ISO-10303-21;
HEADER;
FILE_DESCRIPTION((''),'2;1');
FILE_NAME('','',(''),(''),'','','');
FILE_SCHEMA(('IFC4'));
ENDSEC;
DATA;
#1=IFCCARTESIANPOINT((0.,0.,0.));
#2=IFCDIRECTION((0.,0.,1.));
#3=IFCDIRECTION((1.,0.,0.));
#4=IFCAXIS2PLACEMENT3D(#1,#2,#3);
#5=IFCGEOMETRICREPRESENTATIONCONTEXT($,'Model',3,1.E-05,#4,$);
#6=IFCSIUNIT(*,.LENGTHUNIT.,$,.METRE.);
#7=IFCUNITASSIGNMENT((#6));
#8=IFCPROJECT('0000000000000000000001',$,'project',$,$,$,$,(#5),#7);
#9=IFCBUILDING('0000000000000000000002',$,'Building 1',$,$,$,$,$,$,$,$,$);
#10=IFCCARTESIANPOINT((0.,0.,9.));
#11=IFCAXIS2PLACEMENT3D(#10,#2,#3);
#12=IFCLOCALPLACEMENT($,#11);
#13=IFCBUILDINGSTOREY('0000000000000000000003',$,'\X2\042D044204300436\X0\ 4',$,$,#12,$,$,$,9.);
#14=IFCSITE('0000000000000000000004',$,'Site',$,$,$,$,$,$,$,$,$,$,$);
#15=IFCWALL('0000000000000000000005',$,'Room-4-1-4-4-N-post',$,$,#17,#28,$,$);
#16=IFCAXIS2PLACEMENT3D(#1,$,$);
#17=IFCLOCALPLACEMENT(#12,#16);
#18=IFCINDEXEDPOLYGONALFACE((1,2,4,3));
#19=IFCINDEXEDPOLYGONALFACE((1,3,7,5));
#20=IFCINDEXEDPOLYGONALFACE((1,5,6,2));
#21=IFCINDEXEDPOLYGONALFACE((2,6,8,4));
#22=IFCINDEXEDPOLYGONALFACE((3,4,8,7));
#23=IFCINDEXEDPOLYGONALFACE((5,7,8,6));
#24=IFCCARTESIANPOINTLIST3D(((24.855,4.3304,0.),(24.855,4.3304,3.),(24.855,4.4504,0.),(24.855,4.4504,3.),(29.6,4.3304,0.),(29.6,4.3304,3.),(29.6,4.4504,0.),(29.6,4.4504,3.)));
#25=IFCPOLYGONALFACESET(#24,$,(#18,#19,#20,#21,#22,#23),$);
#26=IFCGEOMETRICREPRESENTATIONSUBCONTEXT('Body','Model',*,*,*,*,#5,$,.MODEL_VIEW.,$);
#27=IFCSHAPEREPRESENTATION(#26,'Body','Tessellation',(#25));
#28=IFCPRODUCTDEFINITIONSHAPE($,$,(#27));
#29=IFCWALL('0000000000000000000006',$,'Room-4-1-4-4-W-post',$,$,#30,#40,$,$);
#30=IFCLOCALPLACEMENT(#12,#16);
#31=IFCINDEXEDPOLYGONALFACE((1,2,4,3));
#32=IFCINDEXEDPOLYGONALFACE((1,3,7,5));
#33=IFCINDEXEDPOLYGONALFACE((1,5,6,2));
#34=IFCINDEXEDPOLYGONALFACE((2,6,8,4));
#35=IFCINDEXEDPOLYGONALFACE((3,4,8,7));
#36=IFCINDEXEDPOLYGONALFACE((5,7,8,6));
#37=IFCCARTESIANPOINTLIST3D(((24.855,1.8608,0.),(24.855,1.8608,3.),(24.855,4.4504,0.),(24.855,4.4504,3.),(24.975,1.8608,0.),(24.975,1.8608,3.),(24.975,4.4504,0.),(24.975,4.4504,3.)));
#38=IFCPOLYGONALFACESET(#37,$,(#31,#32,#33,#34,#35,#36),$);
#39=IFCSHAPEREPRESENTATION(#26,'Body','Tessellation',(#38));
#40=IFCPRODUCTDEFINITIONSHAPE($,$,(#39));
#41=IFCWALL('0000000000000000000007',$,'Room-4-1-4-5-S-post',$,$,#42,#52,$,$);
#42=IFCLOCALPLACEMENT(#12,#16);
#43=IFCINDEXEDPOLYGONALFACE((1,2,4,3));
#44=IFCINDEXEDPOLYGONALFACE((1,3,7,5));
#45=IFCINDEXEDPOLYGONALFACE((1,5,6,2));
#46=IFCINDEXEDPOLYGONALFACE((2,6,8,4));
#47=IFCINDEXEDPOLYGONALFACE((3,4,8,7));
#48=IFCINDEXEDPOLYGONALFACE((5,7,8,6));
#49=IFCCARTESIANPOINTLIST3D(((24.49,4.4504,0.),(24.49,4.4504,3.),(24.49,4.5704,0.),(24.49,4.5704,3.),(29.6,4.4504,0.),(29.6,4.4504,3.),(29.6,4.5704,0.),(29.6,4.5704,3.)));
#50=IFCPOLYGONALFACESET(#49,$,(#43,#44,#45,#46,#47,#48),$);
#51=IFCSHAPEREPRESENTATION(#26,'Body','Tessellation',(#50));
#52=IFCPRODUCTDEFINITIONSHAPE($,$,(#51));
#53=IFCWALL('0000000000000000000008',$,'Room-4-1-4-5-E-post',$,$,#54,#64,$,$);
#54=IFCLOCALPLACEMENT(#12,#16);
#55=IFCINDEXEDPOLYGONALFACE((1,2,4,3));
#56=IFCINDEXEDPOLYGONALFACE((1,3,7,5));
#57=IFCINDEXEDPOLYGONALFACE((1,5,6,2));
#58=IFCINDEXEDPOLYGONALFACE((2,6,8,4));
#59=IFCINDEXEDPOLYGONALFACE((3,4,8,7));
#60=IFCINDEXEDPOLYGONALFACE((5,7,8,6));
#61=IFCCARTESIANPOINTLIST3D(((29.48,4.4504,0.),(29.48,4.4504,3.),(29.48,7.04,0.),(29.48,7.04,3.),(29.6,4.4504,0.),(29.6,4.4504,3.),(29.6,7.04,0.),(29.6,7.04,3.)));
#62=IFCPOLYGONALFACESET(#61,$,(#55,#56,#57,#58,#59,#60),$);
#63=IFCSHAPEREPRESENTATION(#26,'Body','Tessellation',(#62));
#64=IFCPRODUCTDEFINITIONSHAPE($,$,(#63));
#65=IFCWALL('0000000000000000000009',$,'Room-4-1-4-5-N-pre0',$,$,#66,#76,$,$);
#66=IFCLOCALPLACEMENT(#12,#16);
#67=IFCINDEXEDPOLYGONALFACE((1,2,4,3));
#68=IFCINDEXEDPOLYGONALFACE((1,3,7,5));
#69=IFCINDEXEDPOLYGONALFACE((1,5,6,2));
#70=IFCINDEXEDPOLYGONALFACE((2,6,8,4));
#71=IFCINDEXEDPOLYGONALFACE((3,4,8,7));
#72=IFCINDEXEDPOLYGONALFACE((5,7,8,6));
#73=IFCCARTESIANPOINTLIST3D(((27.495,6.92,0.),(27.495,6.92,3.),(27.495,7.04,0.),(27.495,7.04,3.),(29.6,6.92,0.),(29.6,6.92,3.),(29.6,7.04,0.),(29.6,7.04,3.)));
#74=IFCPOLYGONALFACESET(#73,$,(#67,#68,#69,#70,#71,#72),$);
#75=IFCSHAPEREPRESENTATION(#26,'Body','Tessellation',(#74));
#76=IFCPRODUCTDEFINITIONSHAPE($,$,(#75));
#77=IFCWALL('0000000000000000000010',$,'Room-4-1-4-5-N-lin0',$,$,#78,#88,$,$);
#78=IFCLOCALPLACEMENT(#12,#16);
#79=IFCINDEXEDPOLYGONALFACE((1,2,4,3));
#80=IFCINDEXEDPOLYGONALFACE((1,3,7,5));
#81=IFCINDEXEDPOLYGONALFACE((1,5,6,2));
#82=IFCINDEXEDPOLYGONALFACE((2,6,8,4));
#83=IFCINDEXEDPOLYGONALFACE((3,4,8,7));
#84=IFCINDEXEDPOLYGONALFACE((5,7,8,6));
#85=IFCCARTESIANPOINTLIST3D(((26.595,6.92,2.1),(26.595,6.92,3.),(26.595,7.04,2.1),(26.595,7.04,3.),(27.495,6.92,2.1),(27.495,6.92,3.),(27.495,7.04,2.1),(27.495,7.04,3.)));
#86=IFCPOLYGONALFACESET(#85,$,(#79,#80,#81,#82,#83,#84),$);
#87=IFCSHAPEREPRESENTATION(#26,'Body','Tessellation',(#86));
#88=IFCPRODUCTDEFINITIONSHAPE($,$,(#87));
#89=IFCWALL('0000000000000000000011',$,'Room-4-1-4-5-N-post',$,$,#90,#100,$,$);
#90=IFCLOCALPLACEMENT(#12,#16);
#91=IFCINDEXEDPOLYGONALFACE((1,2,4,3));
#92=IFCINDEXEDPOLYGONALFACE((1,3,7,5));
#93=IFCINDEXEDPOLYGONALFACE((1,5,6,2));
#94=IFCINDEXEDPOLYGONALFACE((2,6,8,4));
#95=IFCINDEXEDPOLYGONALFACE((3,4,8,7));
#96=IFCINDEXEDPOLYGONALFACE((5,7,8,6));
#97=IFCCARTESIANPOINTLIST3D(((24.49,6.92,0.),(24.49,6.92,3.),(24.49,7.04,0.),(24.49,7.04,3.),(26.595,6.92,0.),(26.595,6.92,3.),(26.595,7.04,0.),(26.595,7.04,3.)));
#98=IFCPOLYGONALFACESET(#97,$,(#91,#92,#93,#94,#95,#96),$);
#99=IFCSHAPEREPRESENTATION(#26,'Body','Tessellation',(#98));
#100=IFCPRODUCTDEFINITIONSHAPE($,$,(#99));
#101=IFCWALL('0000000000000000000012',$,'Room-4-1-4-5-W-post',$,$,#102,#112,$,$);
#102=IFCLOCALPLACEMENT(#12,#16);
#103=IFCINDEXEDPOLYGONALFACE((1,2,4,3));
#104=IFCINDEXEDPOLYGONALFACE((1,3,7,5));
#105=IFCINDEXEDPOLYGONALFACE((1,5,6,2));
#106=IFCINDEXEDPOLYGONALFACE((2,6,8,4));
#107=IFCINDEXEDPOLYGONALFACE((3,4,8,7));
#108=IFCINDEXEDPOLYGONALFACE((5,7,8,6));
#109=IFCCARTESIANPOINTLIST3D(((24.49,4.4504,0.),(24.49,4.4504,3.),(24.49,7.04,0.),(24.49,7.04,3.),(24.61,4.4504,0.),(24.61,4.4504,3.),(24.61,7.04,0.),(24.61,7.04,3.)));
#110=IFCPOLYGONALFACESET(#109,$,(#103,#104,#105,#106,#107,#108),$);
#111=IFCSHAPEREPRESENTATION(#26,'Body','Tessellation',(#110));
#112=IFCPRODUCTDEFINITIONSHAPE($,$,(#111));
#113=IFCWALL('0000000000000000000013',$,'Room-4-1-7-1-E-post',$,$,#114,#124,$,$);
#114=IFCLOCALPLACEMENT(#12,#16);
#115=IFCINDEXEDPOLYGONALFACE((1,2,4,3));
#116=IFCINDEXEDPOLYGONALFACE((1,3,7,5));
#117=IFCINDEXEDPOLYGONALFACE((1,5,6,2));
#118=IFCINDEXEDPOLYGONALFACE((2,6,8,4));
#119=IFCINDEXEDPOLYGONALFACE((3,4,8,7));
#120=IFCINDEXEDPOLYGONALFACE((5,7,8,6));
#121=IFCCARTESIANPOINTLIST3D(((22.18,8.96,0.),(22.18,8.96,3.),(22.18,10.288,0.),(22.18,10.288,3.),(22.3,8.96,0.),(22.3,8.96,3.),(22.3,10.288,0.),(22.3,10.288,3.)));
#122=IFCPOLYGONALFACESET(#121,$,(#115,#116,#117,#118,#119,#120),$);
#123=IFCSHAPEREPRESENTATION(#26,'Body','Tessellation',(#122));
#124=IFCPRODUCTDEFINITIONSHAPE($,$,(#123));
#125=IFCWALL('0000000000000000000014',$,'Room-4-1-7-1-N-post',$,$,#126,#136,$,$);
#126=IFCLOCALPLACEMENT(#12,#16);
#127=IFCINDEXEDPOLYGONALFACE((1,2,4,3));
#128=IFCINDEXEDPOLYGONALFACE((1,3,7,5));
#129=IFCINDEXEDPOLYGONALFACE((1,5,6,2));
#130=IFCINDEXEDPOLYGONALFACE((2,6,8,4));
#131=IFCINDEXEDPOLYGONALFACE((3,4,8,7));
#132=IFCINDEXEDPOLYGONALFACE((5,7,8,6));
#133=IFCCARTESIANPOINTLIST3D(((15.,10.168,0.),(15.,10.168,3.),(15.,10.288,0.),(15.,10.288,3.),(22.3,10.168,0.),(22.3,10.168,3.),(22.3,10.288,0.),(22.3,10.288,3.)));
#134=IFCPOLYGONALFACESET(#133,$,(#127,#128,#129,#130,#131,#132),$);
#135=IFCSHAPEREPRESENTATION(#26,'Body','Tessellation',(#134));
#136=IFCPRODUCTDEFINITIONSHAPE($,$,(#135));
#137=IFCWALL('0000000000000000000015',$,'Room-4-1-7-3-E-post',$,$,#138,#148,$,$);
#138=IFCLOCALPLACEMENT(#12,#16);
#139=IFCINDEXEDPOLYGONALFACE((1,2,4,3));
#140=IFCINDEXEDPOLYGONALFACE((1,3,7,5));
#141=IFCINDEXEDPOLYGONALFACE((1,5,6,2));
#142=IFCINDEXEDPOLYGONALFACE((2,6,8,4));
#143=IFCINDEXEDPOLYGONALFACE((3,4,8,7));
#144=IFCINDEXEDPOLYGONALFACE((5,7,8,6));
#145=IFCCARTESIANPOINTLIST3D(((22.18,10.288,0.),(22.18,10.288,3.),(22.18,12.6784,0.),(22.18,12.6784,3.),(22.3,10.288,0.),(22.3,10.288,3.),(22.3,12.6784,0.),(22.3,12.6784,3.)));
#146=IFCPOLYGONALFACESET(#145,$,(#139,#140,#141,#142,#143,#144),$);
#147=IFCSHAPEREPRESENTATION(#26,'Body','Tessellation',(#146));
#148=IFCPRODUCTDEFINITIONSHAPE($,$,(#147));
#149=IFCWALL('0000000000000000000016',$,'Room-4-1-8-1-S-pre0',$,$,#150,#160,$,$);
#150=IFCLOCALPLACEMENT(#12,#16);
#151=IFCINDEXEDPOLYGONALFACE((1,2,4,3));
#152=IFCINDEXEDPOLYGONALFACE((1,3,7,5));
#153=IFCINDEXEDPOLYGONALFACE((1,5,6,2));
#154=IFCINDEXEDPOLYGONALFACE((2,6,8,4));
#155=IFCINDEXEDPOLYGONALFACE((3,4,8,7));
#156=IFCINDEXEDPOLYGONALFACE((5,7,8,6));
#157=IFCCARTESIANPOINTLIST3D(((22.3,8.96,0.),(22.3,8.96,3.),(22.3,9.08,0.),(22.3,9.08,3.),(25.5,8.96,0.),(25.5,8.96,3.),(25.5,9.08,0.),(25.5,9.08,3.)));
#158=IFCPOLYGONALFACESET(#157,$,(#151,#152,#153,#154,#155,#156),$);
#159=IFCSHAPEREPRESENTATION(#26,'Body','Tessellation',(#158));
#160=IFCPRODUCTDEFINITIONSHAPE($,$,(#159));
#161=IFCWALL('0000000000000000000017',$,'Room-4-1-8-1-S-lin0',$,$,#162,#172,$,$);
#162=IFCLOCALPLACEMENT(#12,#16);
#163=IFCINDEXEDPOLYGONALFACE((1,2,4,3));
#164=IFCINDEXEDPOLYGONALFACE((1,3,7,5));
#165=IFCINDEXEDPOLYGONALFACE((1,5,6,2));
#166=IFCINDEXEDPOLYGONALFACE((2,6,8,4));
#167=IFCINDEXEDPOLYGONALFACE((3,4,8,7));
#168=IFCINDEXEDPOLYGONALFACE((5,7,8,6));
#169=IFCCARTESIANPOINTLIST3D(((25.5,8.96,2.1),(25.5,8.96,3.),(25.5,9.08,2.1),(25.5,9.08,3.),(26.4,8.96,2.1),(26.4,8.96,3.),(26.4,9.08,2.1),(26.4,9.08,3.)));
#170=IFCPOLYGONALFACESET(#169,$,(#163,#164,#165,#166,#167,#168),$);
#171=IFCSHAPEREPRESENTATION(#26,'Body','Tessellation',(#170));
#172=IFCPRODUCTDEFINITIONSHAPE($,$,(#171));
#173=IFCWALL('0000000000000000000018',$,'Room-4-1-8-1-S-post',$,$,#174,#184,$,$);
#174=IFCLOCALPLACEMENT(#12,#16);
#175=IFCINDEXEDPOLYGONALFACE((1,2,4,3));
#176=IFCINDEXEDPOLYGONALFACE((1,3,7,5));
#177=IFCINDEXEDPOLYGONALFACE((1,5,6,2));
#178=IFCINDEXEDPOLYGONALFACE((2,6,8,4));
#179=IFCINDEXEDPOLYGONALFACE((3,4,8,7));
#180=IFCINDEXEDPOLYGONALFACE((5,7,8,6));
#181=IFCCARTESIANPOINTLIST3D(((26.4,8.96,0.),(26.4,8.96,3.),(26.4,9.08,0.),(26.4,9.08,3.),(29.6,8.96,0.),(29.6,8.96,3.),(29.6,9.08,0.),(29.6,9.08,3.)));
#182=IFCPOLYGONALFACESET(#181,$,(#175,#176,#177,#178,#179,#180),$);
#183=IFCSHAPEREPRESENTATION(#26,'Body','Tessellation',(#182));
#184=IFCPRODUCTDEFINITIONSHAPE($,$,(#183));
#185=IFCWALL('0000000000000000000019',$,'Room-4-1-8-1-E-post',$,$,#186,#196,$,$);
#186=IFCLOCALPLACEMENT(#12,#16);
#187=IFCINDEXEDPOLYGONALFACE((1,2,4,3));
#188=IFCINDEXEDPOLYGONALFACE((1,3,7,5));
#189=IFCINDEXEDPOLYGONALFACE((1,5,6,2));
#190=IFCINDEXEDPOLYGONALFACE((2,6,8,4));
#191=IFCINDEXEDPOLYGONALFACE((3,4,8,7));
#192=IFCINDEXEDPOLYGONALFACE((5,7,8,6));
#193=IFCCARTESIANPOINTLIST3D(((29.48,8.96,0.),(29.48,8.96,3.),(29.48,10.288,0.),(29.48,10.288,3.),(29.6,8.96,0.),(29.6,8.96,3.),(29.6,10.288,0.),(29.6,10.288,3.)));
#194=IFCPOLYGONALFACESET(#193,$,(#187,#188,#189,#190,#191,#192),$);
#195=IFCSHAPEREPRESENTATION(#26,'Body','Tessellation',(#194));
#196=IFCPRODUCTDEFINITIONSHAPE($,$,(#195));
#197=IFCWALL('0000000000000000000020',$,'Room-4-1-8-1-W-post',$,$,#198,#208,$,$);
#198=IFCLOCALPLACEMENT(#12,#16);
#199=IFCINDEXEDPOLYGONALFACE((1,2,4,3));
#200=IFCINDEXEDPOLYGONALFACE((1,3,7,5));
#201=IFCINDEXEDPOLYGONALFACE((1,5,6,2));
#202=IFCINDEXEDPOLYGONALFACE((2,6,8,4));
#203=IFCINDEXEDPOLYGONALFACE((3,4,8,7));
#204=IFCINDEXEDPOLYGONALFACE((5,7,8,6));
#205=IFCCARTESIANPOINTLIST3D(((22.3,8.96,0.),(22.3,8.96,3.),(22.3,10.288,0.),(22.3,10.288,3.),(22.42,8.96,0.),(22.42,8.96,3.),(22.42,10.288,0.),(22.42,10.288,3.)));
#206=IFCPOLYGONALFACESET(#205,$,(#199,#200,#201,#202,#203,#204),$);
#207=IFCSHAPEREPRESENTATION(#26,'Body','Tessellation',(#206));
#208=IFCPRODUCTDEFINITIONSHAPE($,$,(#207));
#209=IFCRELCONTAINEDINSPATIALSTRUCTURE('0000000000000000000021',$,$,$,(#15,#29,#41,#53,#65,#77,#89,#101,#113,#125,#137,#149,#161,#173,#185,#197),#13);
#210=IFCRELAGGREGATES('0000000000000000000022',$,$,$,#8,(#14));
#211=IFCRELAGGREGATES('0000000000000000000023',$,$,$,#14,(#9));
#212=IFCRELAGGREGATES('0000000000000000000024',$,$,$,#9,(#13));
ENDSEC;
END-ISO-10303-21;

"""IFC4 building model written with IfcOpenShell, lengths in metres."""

from ifc_helpers import new_model, si_unit, frame, origin_with_axes, place, context, subcontext, project, spatial, indexed_curve, outline, extrude, element, save


model = new_model("IFC4")

# Units and contexts
model_context = context("Model", 3, precision=1e-05, world=origin_with_axes())
body_context = subcontext(model_context, "Body", "Model", "MODEL_VIEW")
ifc_project = project(units=[si_unit("LENGTHUNIT", "METRE")], contexts=[model_context])

# Site, building, storey
site = spatial("IfcSite", under=ifc_project, Name="Site")
building = spatial("IfcBuilding", under=site, Name="Building 1")
storey_placement = place(None, frame((0.0, 0.0, 9.0), z_axis=(0.0, 0.0, 1.0), x_axis=(1.0, 0.0, 0.0)))
storey = spatial("IfcBuildingStorey", under=building, at=storey_placement, Name="Этаж 4", Elevation=9.0)

# Walls
wall_1_placement = place(storey_placement, frame((29.6, 4.4504, 0.0), z_axis=(0.0, 0.0, 1.0), x_axis=(-1.0, 0.0, 0.0)))
element("IfcWall", 1, at=wall_1_placement, inside=storey, Name="Room-4-1-4-4-N-post", context=body_context, shape_type="SweptSolid", body=[
    extrude(outline(indexed_curve([(0.0, 0.0), (0.0, 0.12), (4.745, 0.12), (4.745, 0.0), (0.0, 0.0)], self_intersect=False)), origin_with_axes(), (0.0, 0.0, 1.0), 3.0),
])
wall_2_placement = place(storey_placement, frame((24.855, 4.4504, 0.0), z_axis=(0.0, 0.0, 1.0), x_axis=(0.0, -1.0, 0.0)))
element("IfcWall", 2, at=wall_2_placement, inside=storey, Name="Room-4-1-4-4-W-post", context=body_context, shape_type="SweptSolid", body=[
    extrude(outline(indexed_curve([(0.0, 0.0), (0.0, 0.12), (2.5896, 0.12), (2.5896, 0.0), (0.0, 0.0)], self_intersect=False)), origin_with_axes(), (0.0, 0.0, 1.0), 3.0),
])
wall_3_placement = place(storey_placement, frame((24.49, 4.4504, 0.0), z_axis=(0.0, 0.0, 1.0), x_axis=(1.0, 0.0, 0.0)))
element("IfcWall", 3, at=wall_3_placement, inside=storey, Name="Room-4-1-4-5-S-post", context=body_context, shape_type="SweptSolid", body=[
    extrude(outline(indexed_curve([(0.0, 0.0), (0.0, 0.12), (5.11, 0.12), (5.11, 0.0), (0.0, 0.0)], self_intersect=False)), origin_with_axes(), (0.0, 0.0, 1.0), 3.0),
])
wall_4_placement = place(storey_placement, frame((29.6, 4.4504, 0.0), z_axis=(0.0, 0.0, 1.0), x_axis=(0.0, 1.0, 0.0)))
element("IfcWall", 4, at=wall_4_placement, inside=storey, Name="Room-4-1-4-5-E-post", context=body_context, shape_type="SweptSolid", body=[
    extrude(outline(indexed_curve([(0.0, 0.0), (0.0, 0.12), (2.5896, 0.12), (2.5896, 0.0), (0.0, 0.0)], self_intersect=False)), origin_with_axes(), (0.0, 0.0, 1.0), 3.0),
])
wall_5_placement = place(storey_placement, frame((29.6, 7.04, 0.0), z_axis=(0.0, 0.0, 1.0), x_axis=(-1.0, 0.0, 0.0)))
element("IfcWall", 5, at=wall_5_placement, inside=storey, Name="Room-4-1-4-5-N-pre0", context=body_context, shape_type="SweptSolid", body=[
    extrude(outline(indexed_curve([(0.0, 0.0), (0.0, 0.12), (2.105, 0.12), (2.105, 0.0), (0.0, 0.0)], self_intersect=False)), origin_with_axes(), (0.0, 0.0, 1.0), 3.0),
])
wall_6_placement = place(storey_placement, frame((27.495, 7.04, 2.1), z_axis=(0.0, 0.0, 1.0), x_axis=(-1.0, 0.0, 0.0)))
element("IfcWall", 6, at=wall_6_placement, inside=storey, Name="Room-4-1-4-5-N-lin0", context=body_context, shape_type="SweptSolid", body=[
    extrude(outline(indexed_curve([(0.0, 0.0), (0.0, 0.12), (0.9, 0.12), (0.9, 0.0), (0.0, 0.0)], self_intersect=False)), origin_with_axes(), (0.0, 0.0, 1.0), 0.9),
])
wall_7_placement = place(storey_placement, frame((26.595, 7.04, 0.0), z_axis=(0.0, 0.0, 1.0), x_axis=(-1.0, 0.0, 0.0)))
element("IfcWall", 7, at=wall_7_placement, inside=storey, Name="Room-4-1-4-5-N-post", context=body_context, shape_type="SweptSolid", body=[
    extrude(outline(indexed_curve([(0.0, 0.0), (0.0, 0.12), (2.105, 0.12), (2.105, 0.0), (0.0, 0.0)], self_intersect=False)), origin_with_axes(), (0.0, 0.0, 1.0), 3.0),
])
wall_8_placement = place(storey_placement, frame((24.49, 7.04, 0.0), z_axis=(0.0, 0.0, 1.0), x_axis=(0.0, -1.0, 0.0)))
element("IfcWall", 8, at=wall_8_placement, inside=storey, Name="Room-4-1-4-5-W-post", context=body_context, shape_type="SweptSolid", body=[
    extrude(outline(indexed_curve([(0.0, 0.0), (0.0, 0.12), (2.5896, 0.12), (2.5896, 0.0), (0.0, 0.0)], self_intersect=False)), origin_with_axes(), (0.0, 0.0, 1.0), 3.0),
])
wall_9_placement = place(storey_placement, frame((22.3, 8.96, 0.0), z_axis=(0.0, 0.0, 1.0), x_axis=(0.0, 1.0, 0.0)))
element("IfcWall", 9, at=wall_9_placement, inside=storey, Name="Room-4-1-7-1-E-post", context=body_context, shape_type="SweptSolid", body=[
    extrude(outline(indexed_curve([(0.0, 0.0), (0.0, 0.12), (1.328, 0.12), (1.328, 0.0), (0.0, 0.0)], self_intersect=False)), origin_with_axes(), (0.0, 0.0, 1.0), 3.0),
])
wall_10_placement = place(storey_placement, frame((22.3, 10.288, 0.0), z_axis=(0.0, 0.0, 1.0), x_axis=(-1.0, 0.0, 0.0)))
element("IfcWall", 10, at=wall_10_placement, inside=storey, Name="Room-4-1-7-1-N-post", context=body_context, shape_type="SweptSolid", body=[
    extrude(outline(indexed_curve([(0.0, 0.0), (0.0, 0.12), (7.3, 0.12), (7.3, 0.0), (0.0, 0.0)], self_intersect=False)), origin_with_axes(), (0.0, 0.0, 1.0), 3.0),
])
wall_11_placement = place(storey_placement, frame((22.3, 10.288, 0.0), z_axis=(0.0, 0.0, 1.0), x_axis=(0.0, 1.0, 0.0)))
element("IfcWall", 11, at=wall_11_placement, inside=storey, Name="Room-4-1-7-3-E-post", context=body_context, shape_type="SweptSolid", body=[
    extrude(outline(indexed_curve([(0.0, 0.0), (0.0, 0.12), (2.3904, 0.12), (2.3904, 0.0), (0.0, 0.0)], self_intersect=False)), origin_with_axes(), (0.0, 0.0, 1.0), 3.0),
])
wall_12_placement = place(storey_placement, frame((22.3, 8.96, 0.0), z_axis=(0.0, 0.0, 1.0), x_axis=(1.0, 0.0, 0.0)))
element("IfcWall", 12, at=wall_12_placement, inside=storey, Name="Room-4-1-8-1-S-pre0", context=body_context, shape_type="SweptSolid", body=[
    extrude(outline(indexed_curve([(0.0, 0.0), (0.0, 0.12), (3.2, 0.12), (3.2, 0.0), (0.0, 0.0)], self_intersect=False)), origin_with_axes(), (0.0, 0.0, 1.0), 3.0),
])
wall_13_placement = place(storey_placement, frame((25.5, 8.96, 2.1), z_axis=(0.0, 0.0, 1.0), x_axis=(1.0, 0.0, 0.0)))
element("IfcWall", 13, at=wall_13_placement, inside=storey, Name="Room-4-1-8-1-S-lin0", context=body_context, shape_type="SweptSolid", body=[
    extrude(outline(indexed_curve([(0.0, 0.0), (0.0, 0.12), (0.9, 0.12), (0.9, 0.0), (0.0, 0.0)], self_intersect=False)), origin_with_axes(), (0.0, 0.0, 1.0), 0.9),
])
wall_14_placement = place(storey_placement, frame((26.4, 8.96, 0.0), z_axis=(0.0, 0.0, 1.0), x_axis=(1.0, 0.0, 0.0)))
element("IfcWall", 14, at=wall_14_placement, inside=storey, Name="Room-4-1-8-1-S-post", context=body_context, shape_type="SweptSolid", body=[
    extrude(outline(indexed_curve([(0.0, 0.0), (0.0, 0.12), (3.2, 0.12), (3.2, 0.0), (0.0, 0.0)], self_intersect=False)), origin_with_axes(), (0.0, 0.0, 1.0), 3.0),
])
for number, where, z_axis, x_axis, name in (
    (15, (29.6, 8.96, 0.0), (0.0, 0.0, 1.0), (0.0, 1.0, 0.0), "Room-4-1-8-1-E-post"),
    (16, (22.3, 10.288, 0.0), (0.0, 0.0, 1.0), (0.0, -1.0, 0.0), "Room-4-1-8-1-W-post"),
):
    element("IfcWall", number, at=place(storey_placement, frame(where, z_axis=z_axis, x_axis=x_axis)), inside=storey, Name=name, context=body_context, shape_type="SweptSolid", body=[
        extrude(outline(indexed_curve([(0.0, 0.0), (0.0, 0.12), (1.328, 0.12), (1.328, 0.0), (0.0, 0.0)], self_intersect=False)), origin_with_axes(), (0.0, 0.0, 1.0), 3.0),
    ])

save(model, "model.ifc")
